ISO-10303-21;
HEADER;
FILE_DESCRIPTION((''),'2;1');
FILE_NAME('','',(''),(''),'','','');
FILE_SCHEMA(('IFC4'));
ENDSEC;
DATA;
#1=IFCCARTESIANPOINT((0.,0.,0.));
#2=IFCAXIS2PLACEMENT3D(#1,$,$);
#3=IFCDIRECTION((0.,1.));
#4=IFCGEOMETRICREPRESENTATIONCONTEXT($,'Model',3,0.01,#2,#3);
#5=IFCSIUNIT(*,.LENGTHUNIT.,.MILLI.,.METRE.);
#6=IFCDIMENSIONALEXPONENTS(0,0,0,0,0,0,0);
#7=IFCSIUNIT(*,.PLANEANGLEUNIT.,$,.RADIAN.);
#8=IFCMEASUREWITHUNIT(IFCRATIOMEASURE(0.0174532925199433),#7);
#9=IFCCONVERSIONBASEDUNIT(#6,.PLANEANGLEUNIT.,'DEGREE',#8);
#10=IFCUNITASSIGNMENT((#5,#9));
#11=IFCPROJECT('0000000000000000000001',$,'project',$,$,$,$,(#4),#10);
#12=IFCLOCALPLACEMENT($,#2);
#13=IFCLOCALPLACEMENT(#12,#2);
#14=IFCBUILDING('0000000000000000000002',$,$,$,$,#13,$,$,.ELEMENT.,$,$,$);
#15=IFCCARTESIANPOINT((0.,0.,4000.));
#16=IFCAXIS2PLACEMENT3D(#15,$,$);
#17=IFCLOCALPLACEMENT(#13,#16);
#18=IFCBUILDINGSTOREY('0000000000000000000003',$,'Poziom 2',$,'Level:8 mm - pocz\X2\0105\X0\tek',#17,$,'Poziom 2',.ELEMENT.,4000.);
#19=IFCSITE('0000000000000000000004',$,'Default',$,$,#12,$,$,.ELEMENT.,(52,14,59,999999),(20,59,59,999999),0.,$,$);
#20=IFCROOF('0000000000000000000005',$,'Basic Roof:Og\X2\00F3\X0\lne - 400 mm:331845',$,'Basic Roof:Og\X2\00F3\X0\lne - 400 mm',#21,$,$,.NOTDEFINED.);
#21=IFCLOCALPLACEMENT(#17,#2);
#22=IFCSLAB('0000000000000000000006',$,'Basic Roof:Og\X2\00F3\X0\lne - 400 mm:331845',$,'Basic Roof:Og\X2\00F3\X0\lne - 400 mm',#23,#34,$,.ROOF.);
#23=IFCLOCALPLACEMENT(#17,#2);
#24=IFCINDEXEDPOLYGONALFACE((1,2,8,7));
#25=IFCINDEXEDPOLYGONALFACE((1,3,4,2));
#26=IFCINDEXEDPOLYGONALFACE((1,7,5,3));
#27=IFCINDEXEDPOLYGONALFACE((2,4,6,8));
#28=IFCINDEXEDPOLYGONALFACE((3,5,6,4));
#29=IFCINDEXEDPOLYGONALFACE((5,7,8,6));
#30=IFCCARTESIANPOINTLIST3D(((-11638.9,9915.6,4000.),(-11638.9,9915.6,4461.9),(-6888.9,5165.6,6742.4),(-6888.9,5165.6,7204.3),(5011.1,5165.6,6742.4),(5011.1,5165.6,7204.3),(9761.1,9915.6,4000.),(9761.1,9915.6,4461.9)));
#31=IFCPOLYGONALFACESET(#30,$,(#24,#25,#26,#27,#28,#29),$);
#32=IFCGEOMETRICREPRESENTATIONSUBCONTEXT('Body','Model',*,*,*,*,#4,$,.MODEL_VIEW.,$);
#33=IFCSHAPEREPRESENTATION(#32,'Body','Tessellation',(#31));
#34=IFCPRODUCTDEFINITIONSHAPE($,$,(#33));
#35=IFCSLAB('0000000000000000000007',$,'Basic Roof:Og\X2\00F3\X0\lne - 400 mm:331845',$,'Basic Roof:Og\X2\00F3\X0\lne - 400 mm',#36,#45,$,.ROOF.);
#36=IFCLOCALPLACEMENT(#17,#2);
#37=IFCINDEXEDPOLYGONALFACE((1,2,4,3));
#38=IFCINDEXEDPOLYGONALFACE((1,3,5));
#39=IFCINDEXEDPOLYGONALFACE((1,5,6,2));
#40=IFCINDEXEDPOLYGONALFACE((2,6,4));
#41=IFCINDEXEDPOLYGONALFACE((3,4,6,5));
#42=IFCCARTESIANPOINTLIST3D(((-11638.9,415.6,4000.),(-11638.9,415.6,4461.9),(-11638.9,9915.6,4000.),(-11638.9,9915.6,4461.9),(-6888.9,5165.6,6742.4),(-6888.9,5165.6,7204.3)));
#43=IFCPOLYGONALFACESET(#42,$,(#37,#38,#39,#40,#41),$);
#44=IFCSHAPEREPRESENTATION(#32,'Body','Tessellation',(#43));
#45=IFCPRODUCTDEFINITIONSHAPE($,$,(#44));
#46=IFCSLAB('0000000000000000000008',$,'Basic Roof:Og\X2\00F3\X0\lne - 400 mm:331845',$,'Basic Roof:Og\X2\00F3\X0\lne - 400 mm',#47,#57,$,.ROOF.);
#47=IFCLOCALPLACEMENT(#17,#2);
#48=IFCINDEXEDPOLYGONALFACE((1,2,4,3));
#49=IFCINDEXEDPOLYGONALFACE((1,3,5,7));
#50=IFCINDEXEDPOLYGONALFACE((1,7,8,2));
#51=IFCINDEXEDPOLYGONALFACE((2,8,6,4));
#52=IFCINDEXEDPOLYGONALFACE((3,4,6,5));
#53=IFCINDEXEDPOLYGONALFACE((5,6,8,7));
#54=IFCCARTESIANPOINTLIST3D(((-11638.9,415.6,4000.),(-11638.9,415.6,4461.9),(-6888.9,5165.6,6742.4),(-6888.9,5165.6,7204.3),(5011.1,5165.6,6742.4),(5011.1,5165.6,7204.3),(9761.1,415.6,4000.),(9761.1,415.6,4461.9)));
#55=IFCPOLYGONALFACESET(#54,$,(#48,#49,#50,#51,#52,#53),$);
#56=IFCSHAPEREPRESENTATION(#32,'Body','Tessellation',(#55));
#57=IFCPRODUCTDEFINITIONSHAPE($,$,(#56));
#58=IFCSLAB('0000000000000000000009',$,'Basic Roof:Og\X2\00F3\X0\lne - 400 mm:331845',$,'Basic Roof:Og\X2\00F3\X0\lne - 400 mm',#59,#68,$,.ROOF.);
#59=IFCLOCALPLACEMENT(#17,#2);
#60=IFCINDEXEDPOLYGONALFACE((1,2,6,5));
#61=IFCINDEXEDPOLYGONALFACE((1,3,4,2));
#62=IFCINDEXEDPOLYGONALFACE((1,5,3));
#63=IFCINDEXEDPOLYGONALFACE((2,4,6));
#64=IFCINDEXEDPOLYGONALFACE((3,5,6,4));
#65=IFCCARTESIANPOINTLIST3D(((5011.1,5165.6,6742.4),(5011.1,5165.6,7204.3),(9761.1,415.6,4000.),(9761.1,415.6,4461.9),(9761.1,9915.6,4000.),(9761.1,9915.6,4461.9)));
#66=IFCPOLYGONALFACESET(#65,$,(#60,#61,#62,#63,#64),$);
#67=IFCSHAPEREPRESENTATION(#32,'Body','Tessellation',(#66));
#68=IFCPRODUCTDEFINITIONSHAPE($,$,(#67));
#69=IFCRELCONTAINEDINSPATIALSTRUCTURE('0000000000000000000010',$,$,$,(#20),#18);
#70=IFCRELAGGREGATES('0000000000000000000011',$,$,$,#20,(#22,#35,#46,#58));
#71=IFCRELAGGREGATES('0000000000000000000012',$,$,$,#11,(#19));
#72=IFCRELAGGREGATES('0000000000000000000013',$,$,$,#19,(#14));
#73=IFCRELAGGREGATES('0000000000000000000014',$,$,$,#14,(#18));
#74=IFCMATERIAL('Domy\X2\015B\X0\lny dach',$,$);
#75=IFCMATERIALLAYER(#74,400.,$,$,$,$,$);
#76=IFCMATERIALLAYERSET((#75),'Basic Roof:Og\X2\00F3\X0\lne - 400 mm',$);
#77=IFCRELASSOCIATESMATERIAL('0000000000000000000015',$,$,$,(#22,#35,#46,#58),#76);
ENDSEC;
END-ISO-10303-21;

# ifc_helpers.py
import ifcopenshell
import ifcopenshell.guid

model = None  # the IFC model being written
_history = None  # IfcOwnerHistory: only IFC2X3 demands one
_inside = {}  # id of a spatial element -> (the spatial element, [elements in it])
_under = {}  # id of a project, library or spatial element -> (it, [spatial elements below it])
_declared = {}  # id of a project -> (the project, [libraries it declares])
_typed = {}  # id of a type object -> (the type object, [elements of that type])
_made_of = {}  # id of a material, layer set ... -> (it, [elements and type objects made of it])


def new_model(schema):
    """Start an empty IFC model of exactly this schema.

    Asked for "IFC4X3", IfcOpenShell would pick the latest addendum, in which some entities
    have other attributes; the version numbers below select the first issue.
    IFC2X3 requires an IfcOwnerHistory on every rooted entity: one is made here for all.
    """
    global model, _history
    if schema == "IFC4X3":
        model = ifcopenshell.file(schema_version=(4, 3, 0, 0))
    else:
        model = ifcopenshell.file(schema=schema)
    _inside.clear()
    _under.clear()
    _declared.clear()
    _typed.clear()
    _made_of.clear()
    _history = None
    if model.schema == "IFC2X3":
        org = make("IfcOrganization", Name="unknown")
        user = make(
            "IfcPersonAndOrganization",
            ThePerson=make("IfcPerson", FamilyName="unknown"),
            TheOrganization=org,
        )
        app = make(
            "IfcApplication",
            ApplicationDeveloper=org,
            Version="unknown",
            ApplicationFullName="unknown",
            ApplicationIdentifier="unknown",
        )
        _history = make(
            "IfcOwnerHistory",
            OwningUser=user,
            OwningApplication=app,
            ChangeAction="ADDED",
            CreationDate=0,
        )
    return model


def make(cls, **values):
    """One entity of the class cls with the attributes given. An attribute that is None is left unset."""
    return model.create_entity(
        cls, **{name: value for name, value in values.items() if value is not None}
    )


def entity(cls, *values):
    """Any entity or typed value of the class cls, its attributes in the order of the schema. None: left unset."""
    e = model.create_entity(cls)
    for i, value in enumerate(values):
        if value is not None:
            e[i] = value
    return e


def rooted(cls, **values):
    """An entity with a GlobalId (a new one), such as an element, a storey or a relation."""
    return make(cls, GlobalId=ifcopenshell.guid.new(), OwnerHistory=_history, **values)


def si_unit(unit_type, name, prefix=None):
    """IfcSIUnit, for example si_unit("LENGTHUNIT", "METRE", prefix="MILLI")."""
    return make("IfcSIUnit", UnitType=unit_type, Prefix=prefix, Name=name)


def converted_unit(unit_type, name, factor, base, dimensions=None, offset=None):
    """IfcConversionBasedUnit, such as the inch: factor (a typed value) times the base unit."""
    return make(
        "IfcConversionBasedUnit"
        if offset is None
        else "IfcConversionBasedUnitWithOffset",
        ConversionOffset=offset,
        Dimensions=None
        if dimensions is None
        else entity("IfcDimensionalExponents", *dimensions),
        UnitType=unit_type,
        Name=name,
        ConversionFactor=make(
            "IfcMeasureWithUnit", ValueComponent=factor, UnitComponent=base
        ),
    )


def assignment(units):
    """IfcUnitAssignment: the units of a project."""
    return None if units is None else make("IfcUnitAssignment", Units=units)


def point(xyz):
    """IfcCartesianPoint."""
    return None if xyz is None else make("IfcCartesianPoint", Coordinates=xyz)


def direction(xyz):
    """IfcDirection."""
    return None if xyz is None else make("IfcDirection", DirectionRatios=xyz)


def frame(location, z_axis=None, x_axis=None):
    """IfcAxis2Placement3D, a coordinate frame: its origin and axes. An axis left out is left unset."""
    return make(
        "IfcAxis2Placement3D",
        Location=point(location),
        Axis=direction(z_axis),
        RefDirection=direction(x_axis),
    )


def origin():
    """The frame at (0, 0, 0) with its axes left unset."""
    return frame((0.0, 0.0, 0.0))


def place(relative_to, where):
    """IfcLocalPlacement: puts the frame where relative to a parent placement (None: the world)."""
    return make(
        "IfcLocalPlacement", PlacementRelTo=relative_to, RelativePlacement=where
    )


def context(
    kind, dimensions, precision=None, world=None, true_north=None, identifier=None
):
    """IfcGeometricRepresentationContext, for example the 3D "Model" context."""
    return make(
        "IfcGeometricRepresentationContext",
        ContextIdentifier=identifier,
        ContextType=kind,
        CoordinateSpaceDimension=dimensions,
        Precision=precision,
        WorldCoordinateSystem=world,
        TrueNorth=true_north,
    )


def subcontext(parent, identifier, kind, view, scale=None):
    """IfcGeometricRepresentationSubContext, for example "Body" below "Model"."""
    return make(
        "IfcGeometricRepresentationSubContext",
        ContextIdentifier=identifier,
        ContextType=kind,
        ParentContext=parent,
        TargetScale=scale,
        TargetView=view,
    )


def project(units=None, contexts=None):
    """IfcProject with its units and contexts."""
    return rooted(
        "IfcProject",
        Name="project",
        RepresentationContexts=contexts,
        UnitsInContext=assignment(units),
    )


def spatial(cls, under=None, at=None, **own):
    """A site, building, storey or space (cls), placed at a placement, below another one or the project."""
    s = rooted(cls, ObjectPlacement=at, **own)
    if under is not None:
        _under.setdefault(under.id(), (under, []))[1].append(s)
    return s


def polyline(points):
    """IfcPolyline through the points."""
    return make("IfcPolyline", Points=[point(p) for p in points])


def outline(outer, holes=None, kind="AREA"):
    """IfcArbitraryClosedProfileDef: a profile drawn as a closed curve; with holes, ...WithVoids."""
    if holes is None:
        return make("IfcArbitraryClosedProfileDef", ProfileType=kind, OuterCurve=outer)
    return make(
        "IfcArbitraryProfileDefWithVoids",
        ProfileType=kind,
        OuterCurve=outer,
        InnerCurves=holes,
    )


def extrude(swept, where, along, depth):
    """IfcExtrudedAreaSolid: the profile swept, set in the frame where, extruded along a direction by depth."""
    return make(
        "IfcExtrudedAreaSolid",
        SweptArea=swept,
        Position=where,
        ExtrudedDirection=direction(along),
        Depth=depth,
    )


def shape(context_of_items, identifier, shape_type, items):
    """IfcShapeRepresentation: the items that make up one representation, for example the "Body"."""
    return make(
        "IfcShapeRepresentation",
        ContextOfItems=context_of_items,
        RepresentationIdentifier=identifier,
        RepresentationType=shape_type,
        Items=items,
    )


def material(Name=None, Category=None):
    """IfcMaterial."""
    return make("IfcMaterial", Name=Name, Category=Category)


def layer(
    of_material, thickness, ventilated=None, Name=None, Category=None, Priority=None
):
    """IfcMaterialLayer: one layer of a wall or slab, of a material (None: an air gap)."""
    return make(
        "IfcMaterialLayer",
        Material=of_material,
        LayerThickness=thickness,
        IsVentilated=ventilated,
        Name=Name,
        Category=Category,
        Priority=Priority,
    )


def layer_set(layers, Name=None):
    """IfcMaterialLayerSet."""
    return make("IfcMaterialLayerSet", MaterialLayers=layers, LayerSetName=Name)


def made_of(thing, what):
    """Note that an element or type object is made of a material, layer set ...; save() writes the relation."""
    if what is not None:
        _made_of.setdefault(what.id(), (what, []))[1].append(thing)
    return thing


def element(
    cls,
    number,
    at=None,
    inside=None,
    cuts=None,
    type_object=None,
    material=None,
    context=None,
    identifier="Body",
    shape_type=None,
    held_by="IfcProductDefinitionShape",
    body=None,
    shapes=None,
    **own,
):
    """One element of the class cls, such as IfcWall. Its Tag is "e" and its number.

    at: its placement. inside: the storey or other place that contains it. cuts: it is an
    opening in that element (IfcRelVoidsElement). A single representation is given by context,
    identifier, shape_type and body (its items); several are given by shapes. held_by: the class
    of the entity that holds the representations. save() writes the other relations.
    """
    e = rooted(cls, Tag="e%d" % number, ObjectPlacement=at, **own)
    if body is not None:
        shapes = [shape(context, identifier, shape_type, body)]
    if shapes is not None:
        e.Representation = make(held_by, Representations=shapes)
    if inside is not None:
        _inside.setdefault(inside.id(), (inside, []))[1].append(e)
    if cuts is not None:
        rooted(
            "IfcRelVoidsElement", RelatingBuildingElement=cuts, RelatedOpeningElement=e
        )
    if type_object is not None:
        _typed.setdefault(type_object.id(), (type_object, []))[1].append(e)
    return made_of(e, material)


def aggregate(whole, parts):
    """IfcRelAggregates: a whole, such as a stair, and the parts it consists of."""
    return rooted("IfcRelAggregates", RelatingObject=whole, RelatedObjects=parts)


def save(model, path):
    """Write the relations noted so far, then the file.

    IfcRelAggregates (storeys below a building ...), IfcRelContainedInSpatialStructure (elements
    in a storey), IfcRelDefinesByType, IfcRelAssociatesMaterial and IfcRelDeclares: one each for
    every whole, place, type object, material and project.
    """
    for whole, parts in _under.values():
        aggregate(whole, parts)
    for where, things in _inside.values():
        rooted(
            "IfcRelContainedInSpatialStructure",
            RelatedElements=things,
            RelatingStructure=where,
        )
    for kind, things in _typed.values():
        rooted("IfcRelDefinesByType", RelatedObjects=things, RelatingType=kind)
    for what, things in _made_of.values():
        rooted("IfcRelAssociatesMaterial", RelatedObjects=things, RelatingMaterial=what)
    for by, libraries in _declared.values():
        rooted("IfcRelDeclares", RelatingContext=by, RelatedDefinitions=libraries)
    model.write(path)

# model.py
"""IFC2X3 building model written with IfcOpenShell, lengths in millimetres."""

from ifc_helpers import new_model, entity, si_unit, converted_unit, direction, frame, origin, place, context, subcontext, project, spatial, polyline, outline, extrude, material, layer, layer_set, element, aggregate, save


model = new_model("IFC2X3")

# Units and contexts
model_context = context("Model", 3, precision=0.01, world=origin(), true_north=direction((0.0, 1.0)))
body_context = subcontext(model_context, "Body", "Model", "MODEL_VIEW")
ifc_project = project(units=[si_unit("LENGTHUNIT", "METRE", prefix="MILLI"), converted_unit("PLANEANGLEUNIT", "DEGREE", entity("IfcRatioMeasure", 0.0174532925199433), si_unit("PLANEANGLEUNIT", "RADIAN"), dimensions=[0, 0, 0, 0, 0, 0, 0])], contexts=[model_context])

# Site, building, storey
site_placement = place(None, origin())
site = spatial("IfcSite", under=ifc_project, at=site_placement, Name="Default", CompositionType="ELEMENT", RefLatitude=(52, 14, 59, 999999), RefLongitude=(20, 59, 59, 999999), RefElevation=0.0)
building_placement = place(site_placement, origin())
building = spatial("IfcBuilding", under=site, at=building_placement, CompositionType="ELEMENT")
storey_placement = place(building_placement, frame((0.0, 0.0, 4000.0)))
storey = spatial("IfcBuildingStorey", under=building, at=storey_placement, Name="Poziom 2", ObjectType="Level:8 mm - początek", LongName="Poziom 2", CompositionType="ELEMENT", Elevation=4000.0)

# Roof, slabs
roof_placement = place(storey_placement, frame((-11638.9, 415.6, 4000.0)))
roof = element("IfcRoof", 1, at=roof_placement, inside=storey, Name="Basic Roof:Ogólne - 400 mm:331845", ObjectType="Basic Roof:Ogólne - 400 mm", ShapeType="NOTDEFINED")
ifc_material = material(Name="Domyślny dach")
ifc_layer = layer(ifc_material, 400.0)
ifc_layer_set = layer_set([ifc_layer], Name="Basic Roof:Ogólne - 400 mm")
slab_1_placement = place(roof_placement, origin())
slab_1 = element("IfcSlab", 2, at=slab_1_placement, material=ifc_layer_set, Name="Basic Roof:Ogólne - 400 mm:331845", ObjectType="Basic Roof:Ogólne - 400 mm", PredefinedType="ROOF", context=body_context, shape_type="SweptSolid", body=[
    extrude(outline(polyline([(10700.0, 2742.4), (-10700.0, 2742.4), (-5950.0, -2742.4), (5950.0, -2742.4), (10700.0, 2742.4)])), frame((10700.0, 7125.0, 1371.2), z_axis=(0.0, 0.5, 0.866025), x_axis=(1.0, 0.0, 0.0)), (0.0, -0.5, 0.866025), 461.9),
])
slab_2_placement = place(roof_placement, origin())
slab_2 = element("IfcSlab", 3, at=slab_2_placement, material=ifc_layer_set, Name="Basic Roof:Ogólne - 400 mm:331845", ObjectType="Basic Roof:Ogólne - 400 mm", PredefinedType="ROOF", context=body_context, shape_type="SweptSolid", body=[
    extrude(outline(polyline([(-2742.4, 4750.0), (-2742.4, -4750.0), (2742.4, 0.0), (-2742.4, 4750.0)])), frame((2375.0, 4750.0, 1371.2), z_axis=(-0.5, 0.0, 0.866025), x_axis=(0.866025, 0.0, 0.5)), (0.5, 0.0, 0.866025), 461.9),
])
slab_3_placement = place(roof_placement, origin())
slab_3 = element("IfcSlab", 4, at=slab_3_placement, material=ifc_layer_set, Name="Basic Roof:Ogólne - 400 mm:331845", ObjectType="Basic Roof:Ogólne - 400 mm", PredefinedType="ROOF", context=body_context, shape_type="SweptSolid", body=[
    extrude(outline(polyline([(-10700.0, -2742.4), (10700.0, -2742.4), (5950.0, 2742.4), (-5950.0, 2742.4), (-10700.0, -2742.4)])), frame((10700.0, 2375.0, 1371.2), z_axis=(0.0, -0.5, 0.866025), x_axis=(1.0, 0.0, 0.0)), (0.0, 0.5, 0.866025), 461.9),
])
slab_4_placement = place(roof_placement, origin())
slab_4 = element("IfcSlab", 5, at=slab_4_placement, material=ifc_layer_set, Name="Basic Roof:Ogólne - 400 mm:331845", ObjectType="Basic Roof:Ogólne - 400 mm", PredefinedType="ROOF", context=body_context, shape_type="SweptSolid", body=[
    extrude(outline(polyline([(-2742.4, 0.0), (2742.4, -4750.0), (2742.4, 4750.0), (-2742.4, 0.0)])), frame((19025.0, 4750.0, 1371.2), z_axis=(0.5, 0.0, 0.866025), x_axis=(0.866025, 0.0, -0.5)), (-0.5, 0.0, 0.866025), 461.9),
])
aggregate(roof, [slab_1, slab_2, slab_3, slab_4])

save(model, "model.ifc")
